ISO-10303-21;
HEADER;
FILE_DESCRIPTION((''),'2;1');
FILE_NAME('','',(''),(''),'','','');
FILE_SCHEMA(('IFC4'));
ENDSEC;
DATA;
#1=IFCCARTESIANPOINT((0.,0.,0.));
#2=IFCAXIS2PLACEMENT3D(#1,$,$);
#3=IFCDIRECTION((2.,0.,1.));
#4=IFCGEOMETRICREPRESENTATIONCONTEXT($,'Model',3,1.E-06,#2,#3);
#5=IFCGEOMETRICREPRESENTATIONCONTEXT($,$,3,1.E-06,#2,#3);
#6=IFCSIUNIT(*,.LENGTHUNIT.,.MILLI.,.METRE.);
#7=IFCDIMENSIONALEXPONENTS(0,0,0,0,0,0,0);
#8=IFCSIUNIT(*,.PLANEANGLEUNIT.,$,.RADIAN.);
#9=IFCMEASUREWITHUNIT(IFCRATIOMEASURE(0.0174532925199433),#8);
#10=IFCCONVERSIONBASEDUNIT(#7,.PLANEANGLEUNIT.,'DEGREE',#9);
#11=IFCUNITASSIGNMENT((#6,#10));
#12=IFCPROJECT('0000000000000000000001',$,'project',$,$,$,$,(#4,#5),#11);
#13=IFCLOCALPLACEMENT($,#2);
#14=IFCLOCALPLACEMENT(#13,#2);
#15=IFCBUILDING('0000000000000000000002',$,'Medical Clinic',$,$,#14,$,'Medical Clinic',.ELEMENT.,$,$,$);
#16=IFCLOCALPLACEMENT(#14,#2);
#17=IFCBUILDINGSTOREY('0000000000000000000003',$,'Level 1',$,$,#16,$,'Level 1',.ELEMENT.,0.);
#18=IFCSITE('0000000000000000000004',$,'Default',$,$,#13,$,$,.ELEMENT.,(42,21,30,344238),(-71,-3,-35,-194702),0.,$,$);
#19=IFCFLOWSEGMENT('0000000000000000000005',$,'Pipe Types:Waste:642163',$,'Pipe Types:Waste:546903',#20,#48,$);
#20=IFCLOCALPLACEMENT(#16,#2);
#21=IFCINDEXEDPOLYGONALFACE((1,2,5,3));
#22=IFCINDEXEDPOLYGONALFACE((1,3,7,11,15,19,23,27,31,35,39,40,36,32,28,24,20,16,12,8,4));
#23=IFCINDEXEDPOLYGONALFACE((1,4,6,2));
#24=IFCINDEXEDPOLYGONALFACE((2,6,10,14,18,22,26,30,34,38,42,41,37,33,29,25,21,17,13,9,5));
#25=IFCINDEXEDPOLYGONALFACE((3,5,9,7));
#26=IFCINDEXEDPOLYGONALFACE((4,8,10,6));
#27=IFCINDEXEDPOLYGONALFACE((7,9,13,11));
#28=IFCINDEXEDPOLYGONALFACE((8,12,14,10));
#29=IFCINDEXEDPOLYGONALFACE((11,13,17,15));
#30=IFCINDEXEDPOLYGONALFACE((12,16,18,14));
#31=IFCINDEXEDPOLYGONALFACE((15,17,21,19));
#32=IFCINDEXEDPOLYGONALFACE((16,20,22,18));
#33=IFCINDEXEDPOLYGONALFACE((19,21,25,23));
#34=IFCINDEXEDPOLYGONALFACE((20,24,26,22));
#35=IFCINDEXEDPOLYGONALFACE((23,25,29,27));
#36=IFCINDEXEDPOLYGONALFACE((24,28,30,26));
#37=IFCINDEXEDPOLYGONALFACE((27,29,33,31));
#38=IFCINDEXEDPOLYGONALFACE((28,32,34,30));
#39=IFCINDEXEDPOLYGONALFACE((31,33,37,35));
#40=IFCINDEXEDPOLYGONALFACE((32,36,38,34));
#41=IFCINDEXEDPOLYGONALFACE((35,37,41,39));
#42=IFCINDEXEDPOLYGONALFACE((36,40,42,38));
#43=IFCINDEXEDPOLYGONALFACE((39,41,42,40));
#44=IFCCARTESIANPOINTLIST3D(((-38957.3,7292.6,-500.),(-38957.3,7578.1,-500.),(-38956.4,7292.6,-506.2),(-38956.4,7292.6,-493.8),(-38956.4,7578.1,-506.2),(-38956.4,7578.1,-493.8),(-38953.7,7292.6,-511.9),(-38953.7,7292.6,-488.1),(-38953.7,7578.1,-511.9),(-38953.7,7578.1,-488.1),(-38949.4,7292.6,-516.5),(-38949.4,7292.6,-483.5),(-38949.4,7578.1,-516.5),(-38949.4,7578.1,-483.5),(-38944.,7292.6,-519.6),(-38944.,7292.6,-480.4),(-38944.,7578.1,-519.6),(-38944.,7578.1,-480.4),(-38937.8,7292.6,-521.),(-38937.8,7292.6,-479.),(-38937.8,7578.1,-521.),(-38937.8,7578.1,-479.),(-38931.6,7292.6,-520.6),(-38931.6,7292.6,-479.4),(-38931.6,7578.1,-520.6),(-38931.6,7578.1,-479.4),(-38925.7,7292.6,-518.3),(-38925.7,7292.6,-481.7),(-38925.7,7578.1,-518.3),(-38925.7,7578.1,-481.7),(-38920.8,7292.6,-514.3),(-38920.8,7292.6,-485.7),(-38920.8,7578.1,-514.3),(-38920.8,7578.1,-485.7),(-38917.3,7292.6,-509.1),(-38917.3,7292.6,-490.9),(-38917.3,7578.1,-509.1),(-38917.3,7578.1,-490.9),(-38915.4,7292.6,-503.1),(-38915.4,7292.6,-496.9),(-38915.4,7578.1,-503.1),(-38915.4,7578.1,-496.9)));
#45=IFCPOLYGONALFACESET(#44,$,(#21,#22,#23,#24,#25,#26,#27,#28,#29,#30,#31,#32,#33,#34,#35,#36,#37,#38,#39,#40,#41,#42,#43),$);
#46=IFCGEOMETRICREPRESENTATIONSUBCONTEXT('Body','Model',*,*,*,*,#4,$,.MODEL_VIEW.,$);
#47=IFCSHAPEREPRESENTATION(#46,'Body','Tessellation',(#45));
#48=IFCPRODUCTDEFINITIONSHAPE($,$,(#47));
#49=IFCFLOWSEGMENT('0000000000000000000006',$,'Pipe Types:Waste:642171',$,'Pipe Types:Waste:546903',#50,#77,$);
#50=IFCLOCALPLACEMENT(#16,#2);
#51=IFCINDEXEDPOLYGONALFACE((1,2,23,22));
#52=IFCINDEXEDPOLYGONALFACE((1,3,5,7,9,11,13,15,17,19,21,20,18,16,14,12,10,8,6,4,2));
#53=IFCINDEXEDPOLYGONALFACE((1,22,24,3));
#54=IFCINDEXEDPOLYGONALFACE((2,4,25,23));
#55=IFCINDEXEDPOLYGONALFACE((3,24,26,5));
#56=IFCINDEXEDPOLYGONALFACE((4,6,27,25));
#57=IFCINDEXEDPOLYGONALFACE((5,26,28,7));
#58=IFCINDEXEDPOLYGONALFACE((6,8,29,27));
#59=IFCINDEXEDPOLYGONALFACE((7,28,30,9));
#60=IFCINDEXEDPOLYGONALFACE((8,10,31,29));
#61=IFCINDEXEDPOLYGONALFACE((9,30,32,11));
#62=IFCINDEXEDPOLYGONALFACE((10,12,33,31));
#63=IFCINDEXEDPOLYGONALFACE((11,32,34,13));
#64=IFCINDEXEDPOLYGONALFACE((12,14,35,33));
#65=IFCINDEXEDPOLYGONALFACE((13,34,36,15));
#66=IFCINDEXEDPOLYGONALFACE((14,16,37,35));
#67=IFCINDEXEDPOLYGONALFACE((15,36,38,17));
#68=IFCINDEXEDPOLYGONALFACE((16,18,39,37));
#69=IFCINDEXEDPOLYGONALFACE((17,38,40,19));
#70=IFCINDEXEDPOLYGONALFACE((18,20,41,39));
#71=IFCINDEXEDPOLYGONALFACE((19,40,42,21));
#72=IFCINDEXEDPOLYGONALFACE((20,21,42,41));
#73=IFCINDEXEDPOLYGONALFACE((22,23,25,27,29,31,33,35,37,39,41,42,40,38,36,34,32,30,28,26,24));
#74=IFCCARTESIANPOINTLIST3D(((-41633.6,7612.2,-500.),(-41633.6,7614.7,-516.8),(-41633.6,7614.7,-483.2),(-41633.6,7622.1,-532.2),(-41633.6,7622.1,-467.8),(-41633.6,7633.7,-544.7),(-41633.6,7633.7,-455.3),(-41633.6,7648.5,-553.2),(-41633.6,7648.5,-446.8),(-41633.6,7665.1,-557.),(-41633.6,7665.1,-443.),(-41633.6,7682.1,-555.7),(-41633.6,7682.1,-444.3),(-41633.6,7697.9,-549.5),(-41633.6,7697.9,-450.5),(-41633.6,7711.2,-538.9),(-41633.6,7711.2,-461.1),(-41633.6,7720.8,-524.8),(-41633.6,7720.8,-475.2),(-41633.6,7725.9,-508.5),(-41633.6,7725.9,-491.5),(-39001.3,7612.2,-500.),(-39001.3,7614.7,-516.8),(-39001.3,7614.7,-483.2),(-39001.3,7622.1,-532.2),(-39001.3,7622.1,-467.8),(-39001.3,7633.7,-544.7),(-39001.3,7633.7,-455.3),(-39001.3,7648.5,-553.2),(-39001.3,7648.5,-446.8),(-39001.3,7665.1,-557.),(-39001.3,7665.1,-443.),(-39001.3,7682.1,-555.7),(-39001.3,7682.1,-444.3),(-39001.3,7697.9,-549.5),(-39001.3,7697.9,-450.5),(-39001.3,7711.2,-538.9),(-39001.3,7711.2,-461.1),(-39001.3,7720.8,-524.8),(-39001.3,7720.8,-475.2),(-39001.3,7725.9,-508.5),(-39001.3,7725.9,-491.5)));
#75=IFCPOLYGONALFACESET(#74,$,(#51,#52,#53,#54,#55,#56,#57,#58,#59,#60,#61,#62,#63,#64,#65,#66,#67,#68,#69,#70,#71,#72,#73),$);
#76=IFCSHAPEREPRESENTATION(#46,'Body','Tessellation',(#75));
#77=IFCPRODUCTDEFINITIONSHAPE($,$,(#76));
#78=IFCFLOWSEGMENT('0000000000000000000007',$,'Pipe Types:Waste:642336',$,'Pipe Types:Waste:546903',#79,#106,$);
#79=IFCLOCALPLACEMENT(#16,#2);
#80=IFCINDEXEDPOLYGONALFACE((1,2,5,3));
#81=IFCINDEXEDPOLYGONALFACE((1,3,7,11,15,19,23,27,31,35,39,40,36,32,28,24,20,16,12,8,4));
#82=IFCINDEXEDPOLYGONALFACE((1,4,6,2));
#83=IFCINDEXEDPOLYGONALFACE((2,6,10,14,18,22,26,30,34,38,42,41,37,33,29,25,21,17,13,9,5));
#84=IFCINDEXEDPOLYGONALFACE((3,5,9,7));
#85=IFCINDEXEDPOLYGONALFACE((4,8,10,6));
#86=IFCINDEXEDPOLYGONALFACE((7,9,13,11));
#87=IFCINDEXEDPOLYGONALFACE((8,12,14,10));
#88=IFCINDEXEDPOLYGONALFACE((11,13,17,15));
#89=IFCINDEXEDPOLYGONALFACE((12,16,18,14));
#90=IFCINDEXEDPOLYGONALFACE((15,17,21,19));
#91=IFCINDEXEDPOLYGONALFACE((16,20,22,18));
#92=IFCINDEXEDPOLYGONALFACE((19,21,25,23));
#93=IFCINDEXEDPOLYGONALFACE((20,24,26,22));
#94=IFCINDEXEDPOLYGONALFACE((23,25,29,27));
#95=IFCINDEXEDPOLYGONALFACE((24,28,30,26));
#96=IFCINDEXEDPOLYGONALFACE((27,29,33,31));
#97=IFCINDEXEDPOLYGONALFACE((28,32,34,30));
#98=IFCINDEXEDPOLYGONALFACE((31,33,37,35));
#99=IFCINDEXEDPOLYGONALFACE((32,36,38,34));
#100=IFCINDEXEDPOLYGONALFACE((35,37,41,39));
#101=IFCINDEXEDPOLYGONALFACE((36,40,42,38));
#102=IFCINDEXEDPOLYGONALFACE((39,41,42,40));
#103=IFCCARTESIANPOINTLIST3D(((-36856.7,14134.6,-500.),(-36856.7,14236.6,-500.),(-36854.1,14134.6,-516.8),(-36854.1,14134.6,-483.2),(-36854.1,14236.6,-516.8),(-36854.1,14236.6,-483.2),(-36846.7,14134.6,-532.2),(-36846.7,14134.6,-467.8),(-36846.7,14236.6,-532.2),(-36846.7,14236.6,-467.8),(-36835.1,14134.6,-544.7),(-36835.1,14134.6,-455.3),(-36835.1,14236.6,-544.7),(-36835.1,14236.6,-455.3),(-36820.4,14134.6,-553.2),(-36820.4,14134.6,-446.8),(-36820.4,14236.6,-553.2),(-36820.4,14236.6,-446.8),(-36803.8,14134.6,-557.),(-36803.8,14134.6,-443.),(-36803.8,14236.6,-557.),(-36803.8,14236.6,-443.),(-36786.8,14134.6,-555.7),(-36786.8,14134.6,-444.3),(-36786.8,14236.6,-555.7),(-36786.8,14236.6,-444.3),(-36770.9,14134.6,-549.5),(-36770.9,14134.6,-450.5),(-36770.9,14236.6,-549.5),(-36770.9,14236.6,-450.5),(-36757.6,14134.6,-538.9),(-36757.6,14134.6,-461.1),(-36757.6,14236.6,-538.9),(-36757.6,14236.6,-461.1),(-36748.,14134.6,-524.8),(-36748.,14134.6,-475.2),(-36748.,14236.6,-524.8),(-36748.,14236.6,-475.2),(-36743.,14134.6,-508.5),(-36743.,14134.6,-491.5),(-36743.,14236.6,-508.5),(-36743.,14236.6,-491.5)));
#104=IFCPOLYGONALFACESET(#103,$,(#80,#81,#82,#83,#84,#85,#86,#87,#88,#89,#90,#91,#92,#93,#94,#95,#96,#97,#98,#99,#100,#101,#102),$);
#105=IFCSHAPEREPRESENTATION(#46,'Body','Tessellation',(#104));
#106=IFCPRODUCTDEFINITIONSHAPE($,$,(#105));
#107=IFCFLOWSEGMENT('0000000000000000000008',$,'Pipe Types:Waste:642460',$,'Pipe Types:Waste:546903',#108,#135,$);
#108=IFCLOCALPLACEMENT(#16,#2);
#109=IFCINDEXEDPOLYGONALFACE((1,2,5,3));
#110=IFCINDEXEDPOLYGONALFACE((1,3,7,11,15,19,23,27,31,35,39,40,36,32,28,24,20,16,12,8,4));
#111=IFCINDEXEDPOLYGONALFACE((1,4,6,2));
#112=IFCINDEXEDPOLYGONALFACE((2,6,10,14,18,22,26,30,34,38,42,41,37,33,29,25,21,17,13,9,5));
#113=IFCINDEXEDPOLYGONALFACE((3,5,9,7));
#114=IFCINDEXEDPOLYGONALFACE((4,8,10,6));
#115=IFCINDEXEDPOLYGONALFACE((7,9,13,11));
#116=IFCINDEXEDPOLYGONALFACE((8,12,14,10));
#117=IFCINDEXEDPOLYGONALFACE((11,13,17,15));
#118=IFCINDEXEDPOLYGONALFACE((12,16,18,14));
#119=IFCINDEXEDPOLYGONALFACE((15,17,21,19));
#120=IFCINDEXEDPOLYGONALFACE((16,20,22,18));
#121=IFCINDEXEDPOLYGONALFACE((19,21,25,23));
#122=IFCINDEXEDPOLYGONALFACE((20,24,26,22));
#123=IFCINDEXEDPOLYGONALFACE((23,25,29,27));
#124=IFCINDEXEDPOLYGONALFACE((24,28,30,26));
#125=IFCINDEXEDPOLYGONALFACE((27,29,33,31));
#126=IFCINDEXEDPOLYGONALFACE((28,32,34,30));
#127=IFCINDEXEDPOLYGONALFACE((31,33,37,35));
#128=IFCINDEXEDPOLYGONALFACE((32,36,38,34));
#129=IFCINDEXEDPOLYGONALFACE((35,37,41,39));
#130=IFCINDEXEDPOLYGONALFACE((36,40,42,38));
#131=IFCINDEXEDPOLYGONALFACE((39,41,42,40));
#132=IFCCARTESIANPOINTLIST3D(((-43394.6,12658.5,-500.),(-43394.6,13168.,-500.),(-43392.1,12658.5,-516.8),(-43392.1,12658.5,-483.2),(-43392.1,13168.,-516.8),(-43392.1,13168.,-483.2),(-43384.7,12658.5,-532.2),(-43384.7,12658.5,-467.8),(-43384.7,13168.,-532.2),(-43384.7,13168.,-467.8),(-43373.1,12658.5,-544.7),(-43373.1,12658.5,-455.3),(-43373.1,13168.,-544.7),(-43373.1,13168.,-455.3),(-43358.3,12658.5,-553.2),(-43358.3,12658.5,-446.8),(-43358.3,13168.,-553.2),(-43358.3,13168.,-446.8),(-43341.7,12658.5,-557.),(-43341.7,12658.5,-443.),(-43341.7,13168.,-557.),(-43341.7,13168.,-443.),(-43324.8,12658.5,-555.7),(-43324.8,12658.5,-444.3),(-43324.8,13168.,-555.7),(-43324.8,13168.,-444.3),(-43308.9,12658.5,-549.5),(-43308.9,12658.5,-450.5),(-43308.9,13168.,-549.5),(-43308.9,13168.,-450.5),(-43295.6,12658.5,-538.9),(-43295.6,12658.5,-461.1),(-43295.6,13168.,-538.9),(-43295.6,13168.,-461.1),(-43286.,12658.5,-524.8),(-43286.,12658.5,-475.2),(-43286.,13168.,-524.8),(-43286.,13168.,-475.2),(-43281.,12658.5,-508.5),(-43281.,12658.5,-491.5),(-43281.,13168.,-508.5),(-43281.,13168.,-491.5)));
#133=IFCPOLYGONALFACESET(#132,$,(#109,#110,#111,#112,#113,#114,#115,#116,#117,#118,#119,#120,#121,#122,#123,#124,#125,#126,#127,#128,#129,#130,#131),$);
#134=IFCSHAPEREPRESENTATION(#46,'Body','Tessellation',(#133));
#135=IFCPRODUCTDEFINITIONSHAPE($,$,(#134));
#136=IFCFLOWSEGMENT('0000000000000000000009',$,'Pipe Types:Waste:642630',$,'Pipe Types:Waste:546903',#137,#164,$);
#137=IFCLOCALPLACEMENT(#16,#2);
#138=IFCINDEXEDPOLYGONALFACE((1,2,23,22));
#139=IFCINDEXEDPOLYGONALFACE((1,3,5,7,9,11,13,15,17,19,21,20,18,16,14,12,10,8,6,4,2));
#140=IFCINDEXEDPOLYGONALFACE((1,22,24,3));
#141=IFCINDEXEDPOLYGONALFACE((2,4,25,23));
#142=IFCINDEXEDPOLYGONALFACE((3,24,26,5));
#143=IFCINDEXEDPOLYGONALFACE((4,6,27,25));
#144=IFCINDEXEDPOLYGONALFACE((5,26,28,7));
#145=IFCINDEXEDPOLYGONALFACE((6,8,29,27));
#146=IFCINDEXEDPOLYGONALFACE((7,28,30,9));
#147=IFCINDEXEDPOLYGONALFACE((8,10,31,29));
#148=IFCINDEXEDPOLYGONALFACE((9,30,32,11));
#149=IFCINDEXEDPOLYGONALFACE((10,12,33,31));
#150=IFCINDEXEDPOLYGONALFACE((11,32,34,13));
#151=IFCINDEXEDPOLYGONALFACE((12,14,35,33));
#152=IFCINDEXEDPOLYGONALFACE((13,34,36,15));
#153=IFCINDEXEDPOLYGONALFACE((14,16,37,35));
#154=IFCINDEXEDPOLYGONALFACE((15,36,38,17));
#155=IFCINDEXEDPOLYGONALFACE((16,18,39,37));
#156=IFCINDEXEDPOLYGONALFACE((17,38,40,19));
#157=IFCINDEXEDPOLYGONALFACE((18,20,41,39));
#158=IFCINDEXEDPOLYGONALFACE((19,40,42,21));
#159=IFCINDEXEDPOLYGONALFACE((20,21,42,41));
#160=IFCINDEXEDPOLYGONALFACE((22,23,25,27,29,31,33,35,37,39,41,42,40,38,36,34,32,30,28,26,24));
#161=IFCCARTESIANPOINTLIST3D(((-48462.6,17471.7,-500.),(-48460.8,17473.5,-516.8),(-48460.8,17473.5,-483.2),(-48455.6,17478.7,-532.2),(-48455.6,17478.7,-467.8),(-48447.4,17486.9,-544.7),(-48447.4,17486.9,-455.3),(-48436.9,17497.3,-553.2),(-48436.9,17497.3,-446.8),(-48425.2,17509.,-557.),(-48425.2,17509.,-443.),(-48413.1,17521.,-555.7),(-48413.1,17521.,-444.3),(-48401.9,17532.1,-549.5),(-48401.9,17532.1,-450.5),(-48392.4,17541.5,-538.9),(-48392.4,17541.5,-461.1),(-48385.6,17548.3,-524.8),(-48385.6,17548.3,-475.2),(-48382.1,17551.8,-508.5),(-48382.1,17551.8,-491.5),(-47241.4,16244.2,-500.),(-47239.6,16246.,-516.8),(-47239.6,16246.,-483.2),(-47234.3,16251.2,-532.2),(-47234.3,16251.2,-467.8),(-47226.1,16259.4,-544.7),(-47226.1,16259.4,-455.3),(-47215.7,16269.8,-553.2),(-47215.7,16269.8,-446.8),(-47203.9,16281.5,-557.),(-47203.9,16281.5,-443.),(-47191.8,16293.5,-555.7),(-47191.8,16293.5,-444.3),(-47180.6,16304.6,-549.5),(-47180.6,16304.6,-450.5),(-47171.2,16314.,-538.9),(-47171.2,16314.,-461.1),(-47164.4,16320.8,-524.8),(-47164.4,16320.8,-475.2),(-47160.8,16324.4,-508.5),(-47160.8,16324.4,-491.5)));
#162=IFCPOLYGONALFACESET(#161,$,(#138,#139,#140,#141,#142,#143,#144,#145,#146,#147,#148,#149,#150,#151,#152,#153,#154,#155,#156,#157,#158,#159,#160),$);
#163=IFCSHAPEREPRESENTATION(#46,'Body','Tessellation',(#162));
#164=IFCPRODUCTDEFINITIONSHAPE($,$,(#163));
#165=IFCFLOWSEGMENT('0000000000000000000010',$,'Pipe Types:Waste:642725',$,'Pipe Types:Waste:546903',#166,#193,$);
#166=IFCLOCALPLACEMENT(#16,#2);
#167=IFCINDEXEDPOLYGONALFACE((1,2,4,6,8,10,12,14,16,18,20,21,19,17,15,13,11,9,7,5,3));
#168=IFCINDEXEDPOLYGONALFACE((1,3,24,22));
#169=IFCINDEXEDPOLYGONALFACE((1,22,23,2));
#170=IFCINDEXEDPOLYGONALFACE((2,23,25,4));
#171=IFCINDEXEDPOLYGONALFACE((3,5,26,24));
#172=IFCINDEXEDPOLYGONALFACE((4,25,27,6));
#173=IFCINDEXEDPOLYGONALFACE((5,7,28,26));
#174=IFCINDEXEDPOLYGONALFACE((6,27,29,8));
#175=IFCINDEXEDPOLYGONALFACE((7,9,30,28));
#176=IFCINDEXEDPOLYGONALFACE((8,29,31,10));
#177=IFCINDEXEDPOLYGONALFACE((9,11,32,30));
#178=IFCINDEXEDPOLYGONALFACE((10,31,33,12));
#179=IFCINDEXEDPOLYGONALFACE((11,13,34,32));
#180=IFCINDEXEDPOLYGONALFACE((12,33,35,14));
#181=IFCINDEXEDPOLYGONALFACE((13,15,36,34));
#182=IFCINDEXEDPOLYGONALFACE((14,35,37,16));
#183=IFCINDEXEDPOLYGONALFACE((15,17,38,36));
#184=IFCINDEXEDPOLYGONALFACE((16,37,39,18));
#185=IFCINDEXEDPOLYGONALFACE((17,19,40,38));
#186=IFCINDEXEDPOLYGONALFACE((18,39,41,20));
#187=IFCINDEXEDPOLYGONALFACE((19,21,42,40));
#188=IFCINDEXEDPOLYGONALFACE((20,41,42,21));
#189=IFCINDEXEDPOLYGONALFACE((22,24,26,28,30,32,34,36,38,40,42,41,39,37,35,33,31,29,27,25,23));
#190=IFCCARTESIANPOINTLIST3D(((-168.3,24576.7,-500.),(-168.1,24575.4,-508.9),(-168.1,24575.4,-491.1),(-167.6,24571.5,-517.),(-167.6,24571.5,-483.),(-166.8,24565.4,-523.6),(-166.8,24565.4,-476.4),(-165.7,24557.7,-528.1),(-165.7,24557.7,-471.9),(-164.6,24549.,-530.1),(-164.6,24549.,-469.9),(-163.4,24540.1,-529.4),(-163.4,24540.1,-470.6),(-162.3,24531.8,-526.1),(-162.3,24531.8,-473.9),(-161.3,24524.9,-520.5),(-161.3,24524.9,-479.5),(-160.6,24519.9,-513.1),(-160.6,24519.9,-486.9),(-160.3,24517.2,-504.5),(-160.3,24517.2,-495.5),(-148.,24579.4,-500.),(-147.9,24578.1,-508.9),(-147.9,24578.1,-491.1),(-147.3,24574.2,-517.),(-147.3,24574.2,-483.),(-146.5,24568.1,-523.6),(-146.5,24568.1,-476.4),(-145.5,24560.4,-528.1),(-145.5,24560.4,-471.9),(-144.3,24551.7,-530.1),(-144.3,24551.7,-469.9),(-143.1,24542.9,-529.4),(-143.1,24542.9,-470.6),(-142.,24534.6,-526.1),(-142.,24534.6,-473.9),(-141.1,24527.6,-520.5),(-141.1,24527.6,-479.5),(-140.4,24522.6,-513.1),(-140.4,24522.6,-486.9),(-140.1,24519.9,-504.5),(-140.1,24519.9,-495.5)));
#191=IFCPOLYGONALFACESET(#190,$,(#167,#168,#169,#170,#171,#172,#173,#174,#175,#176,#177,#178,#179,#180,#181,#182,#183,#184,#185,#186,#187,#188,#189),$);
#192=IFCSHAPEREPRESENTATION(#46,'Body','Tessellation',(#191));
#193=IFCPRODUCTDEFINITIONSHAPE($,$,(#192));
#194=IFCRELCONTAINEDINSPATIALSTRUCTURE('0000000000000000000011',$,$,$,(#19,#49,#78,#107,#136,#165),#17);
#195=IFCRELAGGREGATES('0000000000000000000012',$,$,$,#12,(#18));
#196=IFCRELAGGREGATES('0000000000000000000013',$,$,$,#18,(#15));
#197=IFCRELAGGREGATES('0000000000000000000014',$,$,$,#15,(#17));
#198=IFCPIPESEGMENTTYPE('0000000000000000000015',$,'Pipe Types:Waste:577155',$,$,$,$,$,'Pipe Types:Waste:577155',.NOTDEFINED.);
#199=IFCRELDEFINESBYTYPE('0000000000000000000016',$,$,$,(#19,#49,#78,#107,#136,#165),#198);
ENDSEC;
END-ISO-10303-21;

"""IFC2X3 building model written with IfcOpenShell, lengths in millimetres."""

from ifc_helpers import new_model, entity, si_unit, converted_unit, direction, frame, frame_2d, origin, origin_2d_with_axis, place, context, subcontext, project, spatial, circle, extrude, type_object, element, save


model = new_model("IFC2X3")

# Units and contexts
model_context = context("Model", 3, precision=1e-06, world=origin(), true_north=direction((2.0, 0.0, 1.0)))
context_of_model = context(None, 3, precision=1e-06, world=origin(), true_north=direction((2.0, 0.0, 1.0)))
body_context = subcontext(model_context, "Body", "Model", "MODEL_VIEW")
ifc_project = project(units=[si_unit("LENGTHUNIT", "METRE", prefix="MILLI"), converted_unit("PLANEANGLEUNIT", "DEGREE", entity("IfcRatioMeasure", 0.0174532925199433), si_unit("PLANEANGLEUNIT", "RADIAN"), dimensions=[0, 0, 0, 0, 0, 0, 0])], contexts=[model_context, context_of_model])

# Site, building, storey
site_placement = place(None, origin())
site = spatial("IfcSite", under=ifc_project, at=site_placement, Name="Default", CompositionType="ELEMENT", RefLatitude=(42, 21, 30, 344238), RefLongitude=(-71, -3, -35, -194702), RefElevation=0.0)
building_placement = place(site_placement, origin())
building = spatial("IfcBuilding", under=site, at=building_placement, Name="Medical Clinic", LongName="Medical Clinic", CompositionType="ELEMENT")
storey_placement = place(building_placement, origin())
storey = spatial("IfcBuildingStorey", under=building, at=storey_placement, Name="Level 1", LongName="Level 1", CompositionType="ELEMENT", Elevation=0.0)

# Flow segments
pipe_segment_type_1 = type_object("IfcPipeSegmentType", Name="Pipe Types:Waste:577155", ElementType="Pipe Types:Waste:577155", PredefinedType="NOTDEFINED")
flow_segment_1_placement = place(storey_placement, origin())
element("IfcFlowSegment", 1, at=flow_segment_1_placement, inside=storey, type_object=pipe_segment_type_1, Name="Pipe Types:Waste:642163", ObjectType="Pipe Types:Waste:546903", context=body_context, shape_type="SweptSolid", body=[
    extrude(circle(Radius=21.1, at=frame_2d((0.0, 0.0), x_axis=(1.0, 0.0))), frame((-38936.2, 7292.6, -500.0), z_axis=(0.0, 1.0, 0.0), x_axis=(-1.0, 0.0, 0.0)), (0.0, 0.0, 1.0), 285.5),
])
flow_segment_2_placement = place(storey_placement, origin())
element("IfcFlowSegment", 2, at=flow_segment_2_placement, inside=storey, type_object=pipe_segment_type_1, Name="Pipe Types:Waste:642171", ObjectType="Pipe Types:Waste:546903", context=body_context, shape_type="SweptSolid", body=[
    extrude(circle(Radius=57.1, at=frame_2d((0.0, 0.0), x_axis=(1.0, 0.0))), frame((-41633.6, 7669.4, -500.0), z_axis=(1.0, 0.0, 0.0), x_axis=(0.0, -1.0, 0.0)), (0.0, 0.0, 1.0), 2632.2),
])
flow_segment_3_placement = place(storey_placement, origin())
element("IfcFlowSegment", 3, at=flow_segment_3_placement, inside=storey, type_object=pipe_segment_type_1, Name="Pipe Types:Waste:642336", ObjectType="Pipe Types:Waste:546903", context=body_context, shape_type="SweptSolid", body=[
    extrude(circle(Radius=57.1, at=frame_2d((0.0, 0.0), x_axis=(1.0, 0.0))), frame((-36799.5, 14134.6, -500.0), z_axis=(0.0, 1.0, 0.0), x_axis=(-1.0, 0.0, 0.0)), (0.0, 0.0, 1.0), 102.0),
])
flow_segment_4_placement = place(storey_placement, origin())
element("IfcFlowSegment", 4, at=flow_segment_4_placement, inside=storey, type_object=pipe_segment_type_1, Name="Pipe Types:Waste:642460", ObjectType="Pipe Types:Waste:546903", context=body_context, shape_type="SweptSolid", body=[
    extrude(circle(Radius=57.1, at=origin_2d_with_axis()), frame((-43337.5, 12658.5, -500.0), z_axis=(0.0, 1.0, 0.0), x_axis=(-1.0, 0.0, 0.0)), (0.0, 0.0, 1.0), 509.6),
])
flow_segment_5_placement = place(storey_placement, origin())
element("IfcFlowSegment", 5, at=flow_segment_5_placement, inside=storey, type_object=pipe_segment_type_1, Name="Pipe Types:Waste:642630", ObjectType="Pipe Types:Waste:546903", context=body_context, shape_type="SweptSolid", body=[
    extrude(circle(Radius=57.1, at=frame_2d((0.0, 0.0), x_axis=(1.0, 0.0))), frame((-47200.9, 16284.5, -500.0), z_axis=(-0.705306, 0.708903, 0.0), x_axis=(-0.708903, -0.705306, 0.0)), (0.0, 0.0, 1.0), 1731.5),
])
flow_segment_6_placement = place(storey_placement, origin())
element("IfcFlowSegment", 6, at=flow_segment_6_placement, inside=storey, type_object=pipe_segment_type_1, Name="Pipe Types:Waste:642725", ObjectType="Pipe Types:Waste:546903", context=body_context, shape_type="SweptSolid", body=[
    extrude(circle(Radius=30.2, at=frame_2d((0.0, 0.0), x_axis=(1.0, 0.0))), frame((-164.3, 24546.8, -500.0), z_axis=(0.991109, 0.133056, 0.0), x_axis=(-0.133056, 0.991109, 0.0)), (0.0, 0.0, 1.0), 20.4),
])

save(model, "model.ifc")
